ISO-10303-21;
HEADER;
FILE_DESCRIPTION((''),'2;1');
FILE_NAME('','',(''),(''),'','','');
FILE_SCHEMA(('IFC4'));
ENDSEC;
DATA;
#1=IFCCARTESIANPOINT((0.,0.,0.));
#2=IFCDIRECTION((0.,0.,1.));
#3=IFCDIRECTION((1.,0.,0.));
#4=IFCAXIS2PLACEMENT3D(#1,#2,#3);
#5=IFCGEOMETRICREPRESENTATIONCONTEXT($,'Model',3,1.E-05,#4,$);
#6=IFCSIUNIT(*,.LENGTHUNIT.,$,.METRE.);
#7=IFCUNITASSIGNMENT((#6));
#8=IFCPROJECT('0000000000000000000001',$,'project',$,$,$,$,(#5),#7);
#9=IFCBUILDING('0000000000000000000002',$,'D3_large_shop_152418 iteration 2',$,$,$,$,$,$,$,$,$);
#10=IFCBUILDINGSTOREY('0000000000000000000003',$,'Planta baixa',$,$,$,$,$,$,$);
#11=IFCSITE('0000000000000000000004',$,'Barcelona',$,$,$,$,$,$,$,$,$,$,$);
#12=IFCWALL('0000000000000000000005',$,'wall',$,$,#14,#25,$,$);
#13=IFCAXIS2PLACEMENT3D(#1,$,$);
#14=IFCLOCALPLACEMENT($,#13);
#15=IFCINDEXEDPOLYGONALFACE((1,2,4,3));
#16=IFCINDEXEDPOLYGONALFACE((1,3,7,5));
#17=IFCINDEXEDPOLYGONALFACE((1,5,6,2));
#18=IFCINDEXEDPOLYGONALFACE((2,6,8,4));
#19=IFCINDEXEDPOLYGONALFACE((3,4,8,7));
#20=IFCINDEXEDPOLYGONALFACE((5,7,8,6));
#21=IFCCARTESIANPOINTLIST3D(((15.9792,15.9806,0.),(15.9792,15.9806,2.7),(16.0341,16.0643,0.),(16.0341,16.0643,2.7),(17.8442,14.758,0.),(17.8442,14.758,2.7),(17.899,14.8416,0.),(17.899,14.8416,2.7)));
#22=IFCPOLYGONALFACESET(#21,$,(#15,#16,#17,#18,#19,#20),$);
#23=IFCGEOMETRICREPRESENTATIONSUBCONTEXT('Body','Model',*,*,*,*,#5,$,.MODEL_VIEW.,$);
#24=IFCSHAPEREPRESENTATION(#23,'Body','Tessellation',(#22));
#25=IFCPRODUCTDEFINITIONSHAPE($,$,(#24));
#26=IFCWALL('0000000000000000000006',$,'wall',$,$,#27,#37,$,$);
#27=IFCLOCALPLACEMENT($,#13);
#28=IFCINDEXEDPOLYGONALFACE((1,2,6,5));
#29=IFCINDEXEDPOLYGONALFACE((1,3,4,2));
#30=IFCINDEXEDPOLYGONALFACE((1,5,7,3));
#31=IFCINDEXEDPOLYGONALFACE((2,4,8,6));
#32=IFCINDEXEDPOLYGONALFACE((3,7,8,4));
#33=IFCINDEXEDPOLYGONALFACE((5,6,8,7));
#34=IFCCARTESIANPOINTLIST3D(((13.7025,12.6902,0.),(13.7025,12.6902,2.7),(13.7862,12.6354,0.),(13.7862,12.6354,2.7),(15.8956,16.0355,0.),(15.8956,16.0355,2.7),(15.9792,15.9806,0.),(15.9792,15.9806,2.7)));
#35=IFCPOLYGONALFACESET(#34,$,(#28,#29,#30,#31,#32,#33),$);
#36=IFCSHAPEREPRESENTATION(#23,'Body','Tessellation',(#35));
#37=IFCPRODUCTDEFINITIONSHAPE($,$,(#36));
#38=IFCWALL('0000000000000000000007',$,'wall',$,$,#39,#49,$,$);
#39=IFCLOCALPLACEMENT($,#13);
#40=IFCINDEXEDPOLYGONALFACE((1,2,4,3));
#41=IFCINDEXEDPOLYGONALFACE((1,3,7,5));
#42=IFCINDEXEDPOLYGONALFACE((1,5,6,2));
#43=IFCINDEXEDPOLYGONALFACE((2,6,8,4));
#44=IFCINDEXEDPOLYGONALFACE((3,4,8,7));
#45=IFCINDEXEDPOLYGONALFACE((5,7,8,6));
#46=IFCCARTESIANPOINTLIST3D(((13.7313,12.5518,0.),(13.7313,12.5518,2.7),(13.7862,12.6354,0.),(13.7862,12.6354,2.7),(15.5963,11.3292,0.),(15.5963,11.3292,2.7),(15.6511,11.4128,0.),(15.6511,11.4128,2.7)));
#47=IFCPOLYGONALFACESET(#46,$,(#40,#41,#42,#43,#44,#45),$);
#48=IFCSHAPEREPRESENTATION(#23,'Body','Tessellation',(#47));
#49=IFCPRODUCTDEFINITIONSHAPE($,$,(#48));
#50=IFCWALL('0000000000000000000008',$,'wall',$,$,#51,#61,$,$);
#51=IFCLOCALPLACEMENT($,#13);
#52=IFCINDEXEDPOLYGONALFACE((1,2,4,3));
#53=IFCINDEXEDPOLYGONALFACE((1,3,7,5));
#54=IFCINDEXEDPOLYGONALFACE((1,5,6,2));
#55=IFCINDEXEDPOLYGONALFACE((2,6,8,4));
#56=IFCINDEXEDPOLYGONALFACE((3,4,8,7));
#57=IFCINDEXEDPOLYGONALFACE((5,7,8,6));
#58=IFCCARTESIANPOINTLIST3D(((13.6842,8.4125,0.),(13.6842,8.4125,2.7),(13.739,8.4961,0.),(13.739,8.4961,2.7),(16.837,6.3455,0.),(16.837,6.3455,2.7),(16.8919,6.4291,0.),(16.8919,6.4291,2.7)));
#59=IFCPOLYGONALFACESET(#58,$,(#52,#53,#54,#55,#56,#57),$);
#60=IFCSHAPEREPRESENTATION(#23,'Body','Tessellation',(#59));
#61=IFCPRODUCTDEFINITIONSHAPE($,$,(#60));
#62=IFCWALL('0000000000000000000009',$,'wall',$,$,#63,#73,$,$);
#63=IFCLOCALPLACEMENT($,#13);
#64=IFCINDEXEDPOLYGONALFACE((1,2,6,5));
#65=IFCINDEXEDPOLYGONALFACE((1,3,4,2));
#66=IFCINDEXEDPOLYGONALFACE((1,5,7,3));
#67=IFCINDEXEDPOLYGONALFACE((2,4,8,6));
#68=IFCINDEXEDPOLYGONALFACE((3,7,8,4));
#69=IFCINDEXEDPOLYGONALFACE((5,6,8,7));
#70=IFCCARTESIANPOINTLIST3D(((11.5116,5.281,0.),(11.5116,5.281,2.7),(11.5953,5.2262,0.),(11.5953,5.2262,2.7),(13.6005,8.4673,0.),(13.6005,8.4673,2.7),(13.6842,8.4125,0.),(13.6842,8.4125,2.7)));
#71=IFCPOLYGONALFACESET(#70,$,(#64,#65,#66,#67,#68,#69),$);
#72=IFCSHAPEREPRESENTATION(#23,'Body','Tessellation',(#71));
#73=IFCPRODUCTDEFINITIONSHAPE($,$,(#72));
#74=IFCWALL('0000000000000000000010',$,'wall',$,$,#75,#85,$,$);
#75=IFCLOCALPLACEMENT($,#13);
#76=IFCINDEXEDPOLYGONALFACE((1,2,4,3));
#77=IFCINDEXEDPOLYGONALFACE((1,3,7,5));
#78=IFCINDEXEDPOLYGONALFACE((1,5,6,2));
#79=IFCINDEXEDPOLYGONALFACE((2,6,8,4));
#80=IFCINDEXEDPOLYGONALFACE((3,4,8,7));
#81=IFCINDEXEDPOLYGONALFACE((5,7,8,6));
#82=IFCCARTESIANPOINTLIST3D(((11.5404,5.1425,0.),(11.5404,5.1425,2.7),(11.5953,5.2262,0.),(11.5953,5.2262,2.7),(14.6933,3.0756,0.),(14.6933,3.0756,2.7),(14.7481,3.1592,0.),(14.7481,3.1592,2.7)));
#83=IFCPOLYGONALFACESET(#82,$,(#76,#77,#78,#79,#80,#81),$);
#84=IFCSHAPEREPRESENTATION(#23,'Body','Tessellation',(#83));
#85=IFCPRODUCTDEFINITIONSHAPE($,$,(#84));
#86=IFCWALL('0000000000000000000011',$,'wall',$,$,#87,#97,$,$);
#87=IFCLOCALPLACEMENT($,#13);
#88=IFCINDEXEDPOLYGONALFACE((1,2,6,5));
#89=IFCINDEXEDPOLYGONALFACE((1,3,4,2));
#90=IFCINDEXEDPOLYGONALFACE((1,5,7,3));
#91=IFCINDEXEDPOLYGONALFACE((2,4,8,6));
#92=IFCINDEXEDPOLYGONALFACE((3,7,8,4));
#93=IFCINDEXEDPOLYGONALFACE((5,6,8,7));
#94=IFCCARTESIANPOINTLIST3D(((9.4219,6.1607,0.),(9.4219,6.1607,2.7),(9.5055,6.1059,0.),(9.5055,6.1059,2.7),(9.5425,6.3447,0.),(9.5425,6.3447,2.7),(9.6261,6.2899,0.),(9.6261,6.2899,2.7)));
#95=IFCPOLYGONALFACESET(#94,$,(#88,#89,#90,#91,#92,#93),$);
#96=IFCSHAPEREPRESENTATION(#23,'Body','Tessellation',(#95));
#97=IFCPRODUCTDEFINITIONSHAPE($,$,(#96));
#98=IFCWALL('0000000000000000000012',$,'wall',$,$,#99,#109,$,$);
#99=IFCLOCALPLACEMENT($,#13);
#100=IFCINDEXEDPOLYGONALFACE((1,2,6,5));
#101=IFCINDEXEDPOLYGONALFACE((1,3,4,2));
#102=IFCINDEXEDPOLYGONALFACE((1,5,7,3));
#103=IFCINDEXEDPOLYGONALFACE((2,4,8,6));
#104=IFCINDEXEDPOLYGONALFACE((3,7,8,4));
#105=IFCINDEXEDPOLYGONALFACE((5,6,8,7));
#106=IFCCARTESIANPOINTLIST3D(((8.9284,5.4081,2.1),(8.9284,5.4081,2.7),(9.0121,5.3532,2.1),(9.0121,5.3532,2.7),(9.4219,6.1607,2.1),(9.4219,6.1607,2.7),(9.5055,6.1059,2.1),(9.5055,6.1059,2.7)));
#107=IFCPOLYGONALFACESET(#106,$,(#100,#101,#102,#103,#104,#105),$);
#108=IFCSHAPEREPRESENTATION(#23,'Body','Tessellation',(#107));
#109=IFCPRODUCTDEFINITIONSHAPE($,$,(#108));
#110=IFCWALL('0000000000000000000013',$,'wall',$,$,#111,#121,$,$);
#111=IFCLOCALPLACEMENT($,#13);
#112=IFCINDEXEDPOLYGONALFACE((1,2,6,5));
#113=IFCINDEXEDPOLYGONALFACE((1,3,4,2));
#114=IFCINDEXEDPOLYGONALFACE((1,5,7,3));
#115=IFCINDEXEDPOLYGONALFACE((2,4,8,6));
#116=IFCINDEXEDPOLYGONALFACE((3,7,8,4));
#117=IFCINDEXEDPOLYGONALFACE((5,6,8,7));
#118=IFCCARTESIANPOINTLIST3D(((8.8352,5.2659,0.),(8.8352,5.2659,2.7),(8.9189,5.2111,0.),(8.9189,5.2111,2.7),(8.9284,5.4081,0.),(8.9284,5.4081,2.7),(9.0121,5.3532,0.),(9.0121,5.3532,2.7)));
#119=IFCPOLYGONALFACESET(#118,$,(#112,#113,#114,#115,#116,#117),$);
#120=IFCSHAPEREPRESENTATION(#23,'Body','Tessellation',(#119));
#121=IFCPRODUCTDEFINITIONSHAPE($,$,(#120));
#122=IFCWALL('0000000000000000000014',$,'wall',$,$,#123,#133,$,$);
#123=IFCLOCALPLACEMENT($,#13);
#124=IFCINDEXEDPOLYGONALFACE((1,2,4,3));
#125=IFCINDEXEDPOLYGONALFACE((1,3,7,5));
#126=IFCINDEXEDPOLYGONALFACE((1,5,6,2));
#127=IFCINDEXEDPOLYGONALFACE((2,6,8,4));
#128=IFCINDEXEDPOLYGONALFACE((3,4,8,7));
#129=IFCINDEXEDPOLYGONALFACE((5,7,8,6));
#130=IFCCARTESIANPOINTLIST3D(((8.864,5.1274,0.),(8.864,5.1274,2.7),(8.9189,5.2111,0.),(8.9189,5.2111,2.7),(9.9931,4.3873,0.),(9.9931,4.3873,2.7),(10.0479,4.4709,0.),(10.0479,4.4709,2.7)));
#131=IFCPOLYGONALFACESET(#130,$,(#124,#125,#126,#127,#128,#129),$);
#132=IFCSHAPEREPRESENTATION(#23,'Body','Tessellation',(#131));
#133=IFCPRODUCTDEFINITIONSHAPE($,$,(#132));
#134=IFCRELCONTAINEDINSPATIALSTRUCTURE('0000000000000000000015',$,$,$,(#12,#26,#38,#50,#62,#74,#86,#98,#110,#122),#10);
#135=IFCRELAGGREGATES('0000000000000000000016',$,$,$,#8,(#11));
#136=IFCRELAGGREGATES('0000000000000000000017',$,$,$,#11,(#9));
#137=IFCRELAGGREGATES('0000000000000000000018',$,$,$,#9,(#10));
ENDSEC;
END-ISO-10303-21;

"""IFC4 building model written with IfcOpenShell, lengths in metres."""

from ifc_helpers import new_model, si_unit, frame, origin, origin_with_axes, place, context, subcontext, project, spatial, polyline, outline, extrude, element, save


model = new_model("IFC4")

# Units and contexts
model_context = context("Model", 3, precision=1e-05, world=origin_with_axes())
body_context = subcontext(model_context, "Body", "Model", "MODEL_VIEW")
ifc_project = project(units=[si_unit("LENGTHUNIT", "METRE")], contexts=[model_context])

# Site, building, storey
site = spatial("IfcSite", under=ifc_project, Name="Barcelona")
building = spatial("IfcBuilding", under=site, Name="D3_large_shop_152418 iteration 2")
storey = spatial("IfcBuildingStorey", under=building, Name="Planta baixa")

# Walls
wall_1_placement = place(None, origin_with_axes())
element("IfcWall", 1, at=wall_1_placement, inside=storey, Name="wall", context=body_context, shape_type="SweptSolid", body=[
    extrude(outline(polyline([(17.8442, 14.758), (15.9792, 15.9806), (16.0341, 16.0643), (17.899, 14.8416), (17.8442, 14.758)])), origin(), (0.0, 0.0, 1.0), 2.7),
])
wall_2_placement = place(None, origin_with_axes())
element("IfcWall", 2, at=wall_2_placement, inside=storey, Name="wall", context=body_context, shape_type="SweptSolid", body=[
    extrude(outline(polyline([(15.9792, 15.9806), (13.7862, 12.6354), (13.7025, 12.6902), (15.8956, 16.0355), (15.9792, 15.9806)])), origin(), (0.0, 0.0, 1.0), 2.7),
])
wall_3_placement = place(None, origin_with_axes())
element("IfcWall", 3, at=wall_3_placement, inside=storey, Name="wall", context=body_context, shape_type="SweptSolid", body=[
    extrude(outline(polyline([(13.7862, 12.6354), (15.6511, 11.4128), (15.5963, 11.3292), (13.7313, 12.5518), (13.7862, 12.6354)])), origin(), (0.0, 0.0, 1.0), 2.7),
])
wall_4_placement = place(None, origin_with_axes())
element("IfcWall", 4, at=wall_4_placement, inside=storey, Name="wall", context=body_context, shape_type="SweptSolid", body=[
    extrude(outline(polyline([(16.837, 6.3455), (13.6842, 8.4125), (13.739, 8.4961), (16.8919, 6.4291), (16.837, 6.3455)])), origin(), (0.0, 0.0, 1.0), 2.7),
])
wall_5_placement = place(None, origin_with_axes())
element("IfcWall", 5, at=wall_5_placement, inside=storey, Name="wall", context=body_context, shape_type="SweptSolid", body=[
    extrude(outline(polyline([(13.6842, 8.4125), (11.5953, 5.2262), (11.5116, 5.281), (13.6005, 8.4673), (13.6842, 8.4125)])), origin(), (0.0, 0.0, 1.0), 2.7),
])
wall_6_placement = place(None, origin_with_axes())
element("IfcWall", 6, at=wall_6_placement, inside=storey, Name="wall", context=body_context, shape_type="SweptSolid", body=[
    extrude(outline(polyline([(11.5953, 5.2262), (14.7481, 3.1592), (14.6933, 3.0756), (11.5404, 5.1425), (11.5953, 5.2262)])), origin(), (0.0, 0.0, 1.0), 2.7),
])
wall_7_placement = place(None, origin_with_axes())
element("IfcWall", 7, at=wall_7_placement, inside=storey, Name="wall", context=body_context, shape_type="SweptSolid", body=[
    extrude(outline(polyline([(9.6261, 6.2899), (9.5055, 6.1059), (9.4219, 6.1607), (9.5425, 6.3447), (9.6261, 6.2899)])), origin(), (0.0, 0.0, 1.0), 2.7),
])
wall_8_placement = place(None, origin_with_axes())
element("IfcWall", 8, at=wall_8_placement, inside=storey, Name="wall", context=body_context, shape_type="SweptSolid", body=[
    extrude(outline(polyline([(9.5055, 6.1059), (9.0121, 5.3532), (8.9284, 5.4081), (9.4219, 6.1607), (9.5055, 6.1059)])), frame((0.0, 0.0, 2.1)), (0.0, 0.0, 1.0), 0.6),
])
wall_9_placement = place(None, origin_with_axes())
element("IfcWall", 9, at=wall_9_placement, inside=storey, Name="wall", context=body_context, shape_type="SweptSolid", body=[
    extrude(outline(polyline([(9.0121, 5.3532), (8.9189, 5.2111), (8.8352, 5.2659), (8.9284, 5.4081), (9.0121, 5.3532)])), origin(), (0.0, 0.0, 1.0), 2.7),
])
wall_10_placement = place(None, origin_with_axes())
element("IfcWall", 10, at=wall_10_placement, inside=storey, Name="wall", context=body_context, shape_type="SweptSolid", body=[
    extrude(outline(polyline([(8.9189, 5.2111), (10.0479, 4.4709), (9.9931, 4.3873), (8.864, 5.1274), (8.9189, 5.2111)])), origin(), (0.0, 0.0, 1.0), 2.7),
])

save(model, "model.ifc")
